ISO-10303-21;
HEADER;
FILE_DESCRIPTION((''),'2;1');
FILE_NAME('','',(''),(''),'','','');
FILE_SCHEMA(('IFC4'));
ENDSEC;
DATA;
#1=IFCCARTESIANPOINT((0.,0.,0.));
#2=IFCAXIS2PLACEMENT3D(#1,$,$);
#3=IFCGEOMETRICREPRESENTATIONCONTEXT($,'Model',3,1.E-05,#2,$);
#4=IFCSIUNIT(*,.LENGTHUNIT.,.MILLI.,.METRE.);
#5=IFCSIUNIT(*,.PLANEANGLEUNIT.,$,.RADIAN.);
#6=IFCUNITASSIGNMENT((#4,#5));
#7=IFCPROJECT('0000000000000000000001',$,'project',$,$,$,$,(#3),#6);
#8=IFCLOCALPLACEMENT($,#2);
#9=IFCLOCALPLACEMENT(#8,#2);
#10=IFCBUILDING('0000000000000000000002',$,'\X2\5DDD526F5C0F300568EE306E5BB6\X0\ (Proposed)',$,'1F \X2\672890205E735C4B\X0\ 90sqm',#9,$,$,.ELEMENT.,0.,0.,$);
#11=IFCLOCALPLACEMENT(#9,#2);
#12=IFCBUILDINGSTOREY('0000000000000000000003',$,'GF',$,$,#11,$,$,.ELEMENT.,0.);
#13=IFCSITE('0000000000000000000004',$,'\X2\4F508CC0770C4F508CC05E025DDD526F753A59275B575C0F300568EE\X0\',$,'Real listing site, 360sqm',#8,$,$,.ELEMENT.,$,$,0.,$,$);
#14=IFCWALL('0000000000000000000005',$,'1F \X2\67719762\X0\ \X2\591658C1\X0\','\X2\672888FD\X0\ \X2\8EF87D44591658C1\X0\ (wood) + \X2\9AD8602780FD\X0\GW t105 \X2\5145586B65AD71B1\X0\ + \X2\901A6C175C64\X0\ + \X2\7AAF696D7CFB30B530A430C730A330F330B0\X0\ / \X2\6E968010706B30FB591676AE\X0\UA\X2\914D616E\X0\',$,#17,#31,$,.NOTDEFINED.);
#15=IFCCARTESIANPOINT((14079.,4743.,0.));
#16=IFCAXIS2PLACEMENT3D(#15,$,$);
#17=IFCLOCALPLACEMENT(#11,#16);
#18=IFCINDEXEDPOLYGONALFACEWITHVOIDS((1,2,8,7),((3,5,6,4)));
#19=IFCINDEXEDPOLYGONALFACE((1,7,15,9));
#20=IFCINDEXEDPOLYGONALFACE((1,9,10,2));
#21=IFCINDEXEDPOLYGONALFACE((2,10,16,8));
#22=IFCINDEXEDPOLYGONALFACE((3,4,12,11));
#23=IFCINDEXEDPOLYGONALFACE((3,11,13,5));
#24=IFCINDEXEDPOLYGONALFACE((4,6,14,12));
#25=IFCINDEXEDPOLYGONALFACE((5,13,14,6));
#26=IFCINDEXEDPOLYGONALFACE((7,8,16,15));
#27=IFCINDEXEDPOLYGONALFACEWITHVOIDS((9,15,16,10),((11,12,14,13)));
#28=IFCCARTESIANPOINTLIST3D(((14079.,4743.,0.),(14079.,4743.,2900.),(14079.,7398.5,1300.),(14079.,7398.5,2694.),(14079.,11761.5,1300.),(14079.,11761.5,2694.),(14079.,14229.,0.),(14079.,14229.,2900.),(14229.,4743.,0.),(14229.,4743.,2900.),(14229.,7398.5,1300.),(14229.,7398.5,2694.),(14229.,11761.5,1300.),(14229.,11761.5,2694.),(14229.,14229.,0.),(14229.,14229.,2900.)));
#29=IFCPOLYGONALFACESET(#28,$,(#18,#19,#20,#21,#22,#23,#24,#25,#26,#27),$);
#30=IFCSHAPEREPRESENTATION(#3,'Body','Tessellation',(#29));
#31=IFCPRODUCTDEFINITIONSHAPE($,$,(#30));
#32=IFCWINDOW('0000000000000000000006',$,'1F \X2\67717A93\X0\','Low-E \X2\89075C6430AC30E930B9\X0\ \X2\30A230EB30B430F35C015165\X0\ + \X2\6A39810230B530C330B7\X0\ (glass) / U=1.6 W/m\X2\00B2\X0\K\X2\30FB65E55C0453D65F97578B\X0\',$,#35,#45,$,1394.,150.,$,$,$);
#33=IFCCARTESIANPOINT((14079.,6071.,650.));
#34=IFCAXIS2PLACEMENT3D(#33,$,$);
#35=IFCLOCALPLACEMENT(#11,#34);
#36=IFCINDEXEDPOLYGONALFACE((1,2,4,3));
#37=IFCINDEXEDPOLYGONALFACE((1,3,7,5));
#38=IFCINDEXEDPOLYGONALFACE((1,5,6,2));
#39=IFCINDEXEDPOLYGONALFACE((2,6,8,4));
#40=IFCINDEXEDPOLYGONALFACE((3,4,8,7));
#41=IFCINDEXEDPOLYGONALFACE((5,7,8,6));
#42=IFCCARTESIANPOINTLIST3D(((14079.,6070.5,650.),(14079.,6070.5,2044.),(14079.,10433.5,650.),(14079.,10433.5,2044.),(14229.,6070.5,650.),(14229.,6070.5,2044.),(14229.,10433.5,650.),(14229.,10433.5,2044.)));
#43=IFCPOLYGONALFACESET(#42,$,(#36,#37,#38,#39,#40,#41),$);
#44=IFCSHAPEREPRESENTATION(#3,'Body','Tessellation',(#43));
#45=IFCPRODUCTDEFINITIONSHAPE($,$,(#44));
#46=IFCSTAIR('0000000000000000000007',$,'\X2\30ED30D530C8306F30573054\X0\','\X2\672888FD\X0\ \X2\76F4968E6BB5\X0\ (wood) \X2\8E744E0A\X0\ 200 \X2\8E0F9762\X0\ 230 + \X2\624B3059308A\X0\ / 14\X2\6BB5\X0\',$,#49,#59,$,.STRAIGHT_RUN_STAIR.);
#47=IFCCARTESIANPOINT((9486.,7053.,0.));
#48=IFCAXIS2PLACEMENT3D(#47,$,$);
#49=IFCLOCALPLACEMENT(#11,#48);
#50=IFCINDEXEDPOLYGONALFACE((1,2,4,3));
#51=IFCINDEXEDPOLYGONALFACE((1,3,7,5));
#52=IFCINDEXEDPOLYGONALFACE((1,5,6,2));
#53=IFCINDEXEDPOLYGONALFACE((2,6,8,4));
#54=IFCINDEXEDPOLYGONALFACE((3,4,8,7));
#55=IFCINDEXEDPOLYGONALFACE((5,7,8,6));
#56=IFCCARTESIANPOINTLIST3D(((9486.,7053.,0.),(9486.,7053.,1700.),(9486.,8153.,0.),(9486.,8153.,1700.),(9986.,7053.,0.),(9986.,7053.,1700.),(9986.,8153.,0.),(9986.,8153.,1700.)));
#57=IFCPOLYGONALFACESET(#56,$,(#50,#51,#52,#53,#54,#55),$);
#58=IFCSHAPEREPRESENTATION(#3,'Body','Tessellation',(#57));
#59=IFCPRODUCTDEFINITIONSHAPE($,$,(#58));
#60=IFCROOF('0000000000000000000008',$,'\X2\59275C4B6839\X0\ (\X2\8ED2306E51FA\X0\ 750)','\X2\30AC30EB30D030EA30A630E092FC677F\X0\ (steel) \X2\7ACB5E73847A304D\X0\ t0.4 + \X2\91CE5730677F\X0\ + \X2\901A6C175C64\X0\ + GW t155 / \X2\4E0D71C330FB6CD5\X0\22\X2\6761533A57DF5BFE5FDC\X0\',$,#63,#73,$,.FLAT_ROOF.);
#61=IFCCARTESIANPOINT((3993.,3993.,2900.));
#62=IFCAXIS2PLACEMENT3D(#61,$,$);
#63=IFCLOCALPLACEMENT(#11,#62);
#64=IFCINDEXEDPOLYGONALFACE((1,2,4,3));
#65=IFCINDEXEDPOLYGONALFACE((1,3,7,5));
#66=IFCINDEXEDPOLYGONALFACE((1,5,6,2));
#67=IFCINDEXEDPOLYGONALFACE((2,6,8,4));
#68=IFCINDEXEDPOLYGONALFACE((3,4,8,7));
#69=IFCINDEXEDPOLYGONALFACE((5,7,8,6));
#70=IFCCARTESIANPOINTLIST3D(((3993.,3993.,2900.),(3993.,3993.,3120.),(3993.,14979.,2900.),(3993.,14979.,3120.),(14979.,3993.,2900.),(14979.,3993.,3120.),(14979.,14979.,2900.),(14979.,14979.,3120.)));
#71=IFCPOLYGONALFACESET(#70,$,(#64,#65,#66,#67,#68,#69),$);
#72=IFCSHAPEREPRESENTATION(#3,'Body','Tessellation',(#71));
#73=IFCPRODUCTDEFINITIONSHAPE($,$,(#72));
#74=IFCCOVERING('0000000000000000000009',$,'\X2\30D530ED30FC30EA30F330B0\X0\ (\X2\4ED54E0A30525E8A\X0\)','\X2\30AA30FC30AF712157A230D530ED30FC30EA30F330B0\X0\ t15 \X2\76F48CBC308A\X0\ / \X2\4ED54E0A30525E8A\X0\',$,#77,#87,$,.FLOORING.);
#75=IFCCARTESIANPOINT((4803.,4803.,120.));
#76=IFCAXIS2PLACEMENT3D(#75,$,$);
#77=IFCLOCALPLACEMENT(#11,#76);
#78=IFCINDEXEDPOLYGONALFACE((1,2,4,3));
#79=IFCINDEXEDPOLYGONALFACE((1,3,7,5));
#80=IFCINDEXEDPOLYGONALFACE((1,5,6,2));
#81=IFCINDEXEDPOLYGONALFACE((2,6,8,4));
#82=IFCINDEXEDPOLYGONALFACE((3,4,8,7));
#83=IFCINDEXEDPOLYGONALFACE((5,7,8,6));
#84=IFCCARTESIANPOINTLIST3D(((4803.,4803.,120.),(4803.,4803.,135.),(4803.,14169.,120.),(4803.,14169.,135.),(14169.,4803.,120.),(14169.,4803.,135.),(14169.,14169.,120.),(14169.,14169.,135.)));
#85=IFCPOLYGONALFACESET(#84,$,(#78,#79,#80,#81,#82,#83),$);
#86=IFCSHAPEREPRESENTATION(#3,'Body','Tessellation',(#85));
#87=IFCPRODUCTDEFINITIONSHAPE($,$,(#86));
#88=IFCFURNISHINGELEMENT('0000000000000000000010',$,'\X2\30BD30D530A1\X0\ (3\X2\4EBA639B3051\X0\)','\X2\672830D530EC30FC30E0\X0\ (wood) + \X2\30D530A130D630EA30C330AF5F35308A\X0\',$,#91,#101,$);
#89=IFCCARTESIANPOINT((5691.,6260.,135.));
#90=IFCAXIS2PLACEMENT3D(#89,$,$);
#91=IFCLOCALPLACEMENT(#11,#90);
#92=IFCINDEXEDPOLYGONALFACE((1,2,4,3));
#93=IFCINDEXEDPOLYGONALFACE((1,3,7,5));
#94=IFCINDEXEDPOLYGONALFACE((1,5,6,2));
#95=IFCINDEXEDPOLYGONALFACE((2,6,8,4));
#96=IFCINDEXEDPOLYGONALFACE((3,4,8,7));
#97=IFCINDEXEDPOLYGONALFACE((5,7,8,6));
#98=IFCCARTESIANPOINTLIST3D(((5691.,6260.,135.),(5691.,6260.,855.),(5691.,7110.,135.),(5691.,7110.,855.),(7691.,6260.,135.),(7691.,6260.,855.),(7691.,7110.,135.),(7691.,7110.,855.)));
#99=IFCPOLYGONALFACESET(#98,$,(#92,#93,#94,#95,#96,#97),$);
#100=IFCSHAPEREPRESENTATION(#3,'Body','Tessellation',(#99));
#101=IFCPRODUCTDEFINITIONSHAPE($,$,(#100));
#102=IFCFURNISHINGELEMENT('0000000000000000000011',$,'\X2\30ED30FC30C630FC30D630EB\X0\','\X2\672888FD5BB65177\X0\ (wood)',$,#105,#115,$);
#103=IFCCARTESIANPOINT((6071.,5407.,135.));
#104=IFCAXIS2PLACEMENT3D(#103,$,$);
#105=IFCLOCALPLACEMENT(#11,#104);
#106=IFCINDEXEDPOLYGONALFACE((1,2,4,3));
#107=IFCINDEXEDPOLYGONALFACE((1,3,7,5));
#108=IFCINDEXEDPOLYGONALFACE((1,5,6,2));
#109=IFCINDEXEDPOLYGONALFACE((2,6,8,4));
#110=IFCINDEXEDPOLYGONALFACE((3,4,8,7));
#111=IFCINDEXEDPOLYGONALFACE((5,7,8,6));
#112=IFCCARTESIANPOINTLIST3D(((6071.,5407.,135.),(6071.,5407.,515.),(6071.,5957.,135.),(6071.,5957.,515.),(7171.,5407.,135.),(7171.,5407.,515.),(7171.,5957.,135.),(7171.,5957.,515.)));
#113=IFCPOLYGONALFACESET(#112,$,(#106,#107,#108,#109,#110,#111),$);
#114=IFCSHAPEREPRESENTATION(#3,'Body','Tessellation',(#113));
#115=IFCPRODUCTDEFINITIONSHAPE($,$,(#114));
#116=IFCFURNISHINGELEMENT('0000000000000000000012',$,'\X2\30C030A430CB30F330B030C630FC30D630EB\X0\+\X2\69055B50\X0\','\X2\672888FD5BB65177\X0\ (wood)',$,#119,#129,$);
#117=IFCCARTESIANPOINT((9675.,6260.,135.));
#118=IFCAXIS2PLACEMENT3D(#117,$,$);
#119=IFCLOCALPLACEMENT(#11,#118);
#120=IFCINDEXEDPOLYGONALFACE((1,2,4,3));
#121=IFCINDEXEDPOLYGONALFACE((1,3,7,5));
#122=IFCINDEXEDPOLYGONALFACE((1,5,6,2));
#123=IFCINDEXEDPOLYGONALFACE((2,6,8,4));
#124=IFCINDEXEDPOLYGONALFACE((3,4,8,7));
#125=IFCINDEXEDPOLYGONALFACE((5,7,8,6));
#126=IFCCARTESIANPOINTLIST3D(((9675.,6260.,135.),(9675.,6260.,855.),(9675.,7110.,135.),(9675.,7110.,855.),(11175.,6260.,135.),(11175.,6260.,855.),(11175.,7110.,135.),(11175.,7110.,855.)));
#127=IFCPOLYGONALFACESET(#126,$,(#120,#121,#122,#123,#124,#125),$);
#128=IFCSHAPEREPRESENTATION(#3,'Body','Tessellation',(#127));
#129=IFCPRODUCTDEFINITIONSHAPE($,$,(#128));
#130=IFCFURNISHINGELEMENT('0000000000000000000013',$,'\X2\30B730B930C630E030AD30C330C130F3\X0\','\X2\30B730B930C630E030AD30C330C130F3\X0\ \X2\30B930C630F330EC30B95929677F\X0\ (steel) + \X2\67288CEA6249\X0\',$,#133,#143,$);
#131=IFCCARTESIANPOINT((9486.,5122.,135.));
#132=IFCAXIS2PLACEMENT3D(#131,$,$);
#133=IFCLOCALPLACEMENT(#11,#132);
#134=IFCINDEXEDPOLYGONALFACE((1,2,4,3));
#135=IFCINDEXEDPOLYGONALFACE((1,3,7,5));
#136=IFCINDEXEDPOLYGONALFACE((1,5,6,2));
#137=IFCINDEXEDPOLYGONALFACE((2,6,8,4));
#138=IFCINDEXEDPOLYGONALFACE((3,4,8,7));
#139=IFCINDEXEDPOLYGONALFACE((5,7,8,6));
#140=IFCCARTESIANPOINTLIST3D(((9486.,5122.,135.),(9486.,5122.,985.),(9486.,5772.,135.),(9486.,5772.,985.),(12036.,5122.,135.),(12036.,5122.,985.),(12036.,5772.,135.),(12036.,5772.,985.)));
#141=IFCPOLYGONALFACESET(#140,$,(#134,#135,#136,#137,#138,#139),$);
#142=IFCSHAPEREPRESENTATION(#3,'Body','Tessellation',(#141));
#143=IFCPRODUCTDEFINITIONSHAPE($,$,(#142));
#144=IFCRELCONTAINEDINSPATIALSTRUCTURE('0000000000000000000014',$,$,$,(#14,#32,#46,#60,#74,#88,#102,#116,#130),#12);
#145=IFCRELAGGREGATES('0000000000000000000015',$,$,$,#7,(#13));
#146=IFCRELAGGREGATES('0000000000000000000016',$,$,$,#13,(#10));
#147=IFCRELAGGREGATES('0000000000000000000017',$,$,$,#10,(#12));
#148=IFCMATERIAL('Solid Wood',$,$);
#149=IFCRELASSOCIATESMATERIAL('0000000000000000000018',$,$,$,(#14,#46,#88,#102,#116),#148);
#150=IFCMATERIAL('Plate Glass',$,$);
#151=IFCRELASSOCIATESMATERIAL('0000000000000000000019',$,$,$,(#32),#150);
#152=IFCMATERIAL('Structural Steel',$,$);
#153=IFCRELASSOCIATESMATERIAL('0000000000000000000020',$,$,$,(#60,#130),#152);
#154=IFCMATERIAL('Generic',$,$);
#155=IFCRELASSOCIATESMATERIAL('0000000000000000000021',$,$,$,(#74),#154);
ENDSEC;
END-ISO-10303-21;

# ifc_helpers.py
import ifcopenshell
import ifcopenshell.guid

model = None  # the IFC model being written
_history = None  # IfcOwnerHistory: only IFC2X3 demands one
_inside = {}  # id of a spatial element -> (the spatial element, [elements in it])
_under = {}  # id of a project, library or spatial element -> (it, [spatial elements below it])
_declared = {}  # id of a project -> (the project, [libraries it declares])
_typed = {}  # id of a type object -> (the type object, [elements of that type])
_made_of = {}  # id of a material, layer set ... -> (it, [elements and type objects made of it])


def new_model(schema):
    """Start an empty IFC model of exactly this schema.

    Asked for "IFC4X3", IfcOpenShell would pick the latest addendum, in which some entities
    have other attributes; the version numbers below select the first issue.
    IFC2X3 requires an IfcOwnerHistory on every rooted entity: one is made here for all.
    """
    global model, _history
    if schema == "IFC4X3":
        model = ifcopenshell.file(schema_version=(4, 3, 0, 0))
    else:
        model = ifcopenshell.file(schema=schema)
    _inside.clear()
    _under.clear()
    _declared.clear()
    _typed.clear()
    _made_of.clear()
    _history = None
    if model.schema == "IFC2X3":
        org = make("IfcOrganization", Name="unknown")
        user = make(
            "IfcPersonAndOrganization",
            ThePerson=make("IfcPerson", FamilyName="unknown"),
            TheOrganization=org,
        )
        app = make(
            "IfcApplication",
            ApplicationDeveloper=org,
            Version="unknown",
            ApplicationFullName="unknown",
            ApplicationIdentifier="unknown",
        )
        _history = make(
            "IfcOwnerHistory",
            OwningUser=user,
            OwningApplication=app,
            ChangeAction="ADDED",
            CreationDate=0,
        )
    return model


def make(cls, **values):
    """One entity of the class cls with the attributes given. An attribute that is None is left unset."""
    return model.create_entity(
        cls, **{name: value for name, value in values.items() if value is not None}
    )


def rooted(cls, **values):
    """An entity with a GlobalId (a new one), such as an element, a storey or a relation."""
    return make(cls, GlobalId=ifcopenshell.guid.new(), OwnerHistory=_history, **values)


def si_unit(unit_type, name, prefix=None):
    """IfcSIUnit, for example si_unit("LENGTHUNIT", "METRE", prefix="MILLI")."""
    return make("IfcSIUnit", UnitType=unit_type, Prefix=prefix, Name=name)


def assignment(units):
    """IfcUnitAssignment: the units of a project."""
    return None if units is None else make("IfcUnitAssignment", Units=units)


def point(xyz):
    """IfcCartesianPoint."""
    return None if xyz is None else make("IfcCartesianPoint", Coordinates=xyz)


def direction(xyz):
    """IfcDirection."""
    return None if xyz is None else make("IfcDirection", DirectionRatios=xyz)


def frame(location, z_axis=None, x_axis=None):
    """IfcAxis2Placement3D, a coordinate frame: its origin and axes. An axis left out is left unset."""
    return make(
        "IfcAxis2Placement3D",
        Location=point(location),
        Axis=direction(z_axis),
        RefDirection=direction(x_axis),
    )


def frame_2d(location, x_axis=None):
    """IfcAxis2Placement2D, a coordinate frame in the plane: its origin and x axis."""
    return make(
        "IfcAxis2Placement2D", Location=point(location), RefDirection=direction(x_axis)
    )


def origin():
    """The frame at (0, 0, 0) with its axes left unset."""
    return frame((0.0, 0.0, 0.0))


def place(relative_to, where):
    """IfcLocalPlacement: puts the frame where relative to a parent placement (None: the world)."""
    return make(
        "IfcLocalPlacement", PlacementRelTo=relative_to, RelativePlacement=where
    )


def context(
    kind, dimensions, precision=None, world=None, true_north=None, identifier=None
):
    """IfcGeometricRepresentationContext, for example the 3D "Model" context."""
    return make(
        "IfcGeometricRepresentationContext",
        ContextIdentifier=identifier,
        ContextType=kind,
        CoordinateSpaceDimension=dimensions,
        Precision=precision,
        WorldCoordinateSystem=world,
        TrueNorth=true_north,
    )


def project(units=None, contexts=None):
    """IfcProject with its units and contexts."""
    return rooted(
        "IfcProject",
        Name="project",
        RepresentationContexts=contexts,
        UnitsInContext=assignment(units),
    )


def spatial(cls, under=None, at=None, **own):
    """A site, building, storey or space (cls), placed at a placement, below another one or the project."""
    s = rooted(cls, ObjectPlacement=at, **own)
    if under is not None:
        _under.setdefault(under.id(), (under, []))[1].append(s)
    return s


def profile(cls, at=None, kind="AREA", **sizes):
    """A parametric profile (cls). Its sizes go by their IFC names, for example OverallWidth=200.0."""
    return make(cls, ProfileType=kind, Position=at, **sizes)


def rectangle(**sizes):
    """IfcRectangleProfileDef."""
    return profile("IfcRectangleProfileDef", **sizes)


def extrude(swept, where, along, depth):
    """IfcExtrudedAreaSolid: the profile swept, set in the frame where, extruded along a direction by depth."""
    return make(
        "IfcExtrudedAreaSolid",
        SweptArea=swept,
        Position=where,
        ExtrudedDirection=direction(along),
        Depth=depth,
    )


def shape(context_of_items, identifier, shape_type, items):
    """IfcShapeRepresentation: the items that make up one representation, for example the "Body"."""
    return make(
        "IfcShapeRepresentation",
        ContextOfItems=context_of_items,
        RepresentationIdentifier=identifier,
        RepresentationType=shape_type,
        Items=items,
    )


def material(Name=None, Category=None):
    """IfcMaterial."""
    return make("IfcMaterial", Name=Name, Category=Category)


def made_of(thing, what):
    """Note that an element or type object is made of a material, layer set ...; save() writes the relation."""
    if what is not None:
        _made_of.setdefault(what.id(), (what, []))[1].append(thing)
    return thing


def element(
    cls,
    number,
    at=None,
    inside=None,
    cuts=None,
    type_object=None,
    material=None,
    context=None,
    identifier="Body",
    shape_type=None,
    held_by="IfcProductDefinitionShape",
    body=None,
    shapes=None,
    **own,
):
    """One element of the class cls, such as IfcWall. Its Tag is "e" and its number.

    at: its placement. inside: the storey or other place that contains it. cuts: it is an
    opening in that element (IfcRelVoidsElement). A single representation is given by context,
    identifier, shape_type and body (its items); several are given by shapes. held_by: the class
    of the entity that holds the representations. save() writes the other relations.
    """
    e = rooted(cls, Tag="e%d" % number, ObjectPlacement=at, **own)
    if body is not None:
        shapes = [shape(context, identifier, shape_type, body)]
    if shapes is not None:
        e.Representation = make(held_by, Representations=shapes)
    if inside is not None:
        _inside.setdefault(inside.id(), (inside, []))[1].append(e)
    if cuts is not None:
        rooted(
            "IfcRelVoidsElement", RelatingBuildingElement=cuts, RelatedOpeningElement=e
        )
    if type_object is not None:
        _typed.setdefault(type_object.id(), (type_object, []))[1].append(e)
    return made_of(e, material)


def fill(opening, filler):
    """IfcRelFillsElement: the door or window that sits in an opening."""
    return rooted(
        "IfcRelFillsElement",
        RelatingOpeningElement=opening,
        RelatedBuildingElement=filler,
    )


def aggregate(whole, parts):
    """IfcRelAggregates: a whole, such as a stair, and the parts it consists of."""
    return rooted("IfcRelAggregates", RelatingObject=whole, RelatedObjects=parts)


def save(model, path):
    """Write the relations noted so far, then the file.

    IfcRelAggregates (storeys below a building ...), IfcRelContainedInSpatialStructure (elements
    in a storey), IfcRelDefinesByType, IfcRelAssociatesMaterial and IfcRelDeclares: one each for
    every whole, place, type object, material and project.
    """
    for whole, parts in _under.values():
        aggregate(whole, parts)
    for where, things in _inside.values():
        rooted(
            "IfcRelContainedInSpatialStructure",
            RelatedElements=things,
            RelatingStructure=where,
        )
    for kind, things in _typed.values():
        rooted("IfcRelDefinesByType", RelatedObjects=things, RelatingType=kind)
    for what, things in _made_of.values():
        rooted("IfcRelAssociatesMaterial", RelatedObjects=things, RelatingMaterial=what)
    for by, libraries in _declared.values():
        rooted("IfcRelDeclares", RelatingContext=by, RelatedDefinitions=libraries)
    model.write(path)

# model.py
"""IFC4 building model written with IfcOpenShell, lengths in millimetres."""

from ifc_helpers import new_model, si_unit, frame, frame_2d, origin, place, context, project, spatial, rectangle, extrude, material, element, fill, save


model = new_model("IFC4")

# Units and contexts
model_context = context("Model", 3, precision=1e-05, world=origin())
ifc_project = project(units=[si_unit("LENGTHUNIT", "METRE", prefix="MILLI"), si_unit("PLANEANGLEUNIT", "RADIAN")], contexts=[model_context])

# Site, building, storey
site_placement = place(None, origin())
site = spatial("IfcSite", under=ifc_project, at=site_placement, Name="佐賀県佐賀市川副町大字小々森", ObjectType="Real listing site, 360sqm", CompositionType="ELEMENT", RefElevation=0.0)
building_placement = place(site_placement, origin())
building = spatial("IfcBuilding", under=site, at=building_placement, Name="川副小々森の家 (Proposed)", ObjectType="1F 木造平屋 90sqm", CompositionType="ELEMENT", ElevationOfRefHeight=0.0, ElevationOfTerrain=0.0)
storey_placement = place(building_placement, origin())
storey = spatial("IfcBuildingStorey", under=building, at=storey_placement, Name="GF", CompositionType="ELEMENT", Elevation=0.0)

# Shared definitions
ifc_material_1 = material(Name="Solid Wood")

# Shared definitions
ifc_material_2 = material(Name="Plate Glass")

# Wall, opening, window
wall_1_placement = place(storey_placement, frame((14079.0, 4743.0, 0.0)))
wall_1 = element("IfcWall", 1, at=wall_1_placement, inside=storey, material=ifc_material_1, Name="1F 東面 外壁", Description="木製 軸組外壁 (wood) + 高性能GW t105 充填断熱 + 通気層 + 窯業系サイディング / 準耐火・外皮UA配慮", PredefinedType="NOTDEFINED", context=model_context, shape_type="SweptSolid", body=[
    extrude(rectangle(XDim=150.0, YDim=9486.0, at=frame_2d((75.0, 4743.0))), frame((14079.0, 4743.0, 0.0)), (0.0, 0.0, 1.0), 2900.0),
])
opening_1_placement = place(storey_placement, frame((14079.0, 6071.0, 650.0)))
opening_1 = element("IfcOpeningElement", 2, at=opening_1_placement, cuts=wall_1, PredefinedType="NOTDEFINED", context=model_context, shape_type="SweptSolid", body=[
    extrude(rectangle(XDim=150.0, YDim=4363.0, at=frame_2d((75.0, 2181.0))), frame((14079.0, 6071.0, 650.0)), (0.0, 0.0, 1.0), 1394.0),
])
window_1_placement = place(storey_placement, frame((14079.0, 6071.0, 650.0)))
window_1 = element("IfcWindow", 3, at=window_1_placement, inside=storey, material=ifc_material_2, Name="1F 東窓", Description="Low-E 複層ガラス アルゴン封入 + 樹脂サッシ (glass) / U=1.6 W/m²K・日射取得型", OverallHeight=1394.0, OverallWidth=150.0, context=model_context, shape_type="SweptSolid", body=[
    extrude(rectangle(XDim=150.0, YDim=4363.0, at=frame_2d((75.0, 2181.0))), frame((14079.0, 6071.0, 650.0)), (0.0, 0.0, 1.0), 1394.0),
])
fill(opening_1, window_1)

# Stair
stair_placement = place(storey_placement, frame((9486.0, 7053.0, 0.0)))
element("IfcStair", 4, at=stair_placement, inside=storey, material=ifc_material_1, Name="ロフトはしご", Description="木製 直階段 (wood) 蹴上 200 踏面 230 + 手すり / 14段", PredefinedType="STRAIGHT_RUN_STAIR", context=model_context, shape_type="SweptSolid", body=[
    extrude(rectangle(XDim=500.0, YDim=1100.0, at=frame_2d((250.0, 550.0))), frame((9486.0, 7053.0, 0.0)), (0.0, 0.0, 1.0), 1700.0),
])

# Roof
ifc_material_3 = material(Name="Structural Steel")
roof_placement = place(storey_placement, frame((3993.0, 3993.0, 2900.0)))
element("IfcRoof", 5, at=roof_placement, inside=storey, material=ifc_material_3, Name="大屋根 (軒の出 750)", Description="ガルバリウム鋼板 (steel) 立平葺き t0.4 + 野地板 + 通気層 + GW t155 / 不燃・法22条区域対応", PredefinedType="FLAT_ROOF", context=model_context, shape_type="SweptSolid", body=[
    extrude(rectangle(XDim=10986.0, YDim=10986.0, at=frame_2d((5493.0, 5493.0))), frame((3993.0, 3993.0, 2900.0)), (0.0, 0.0, 1.0), 220.0),
])

# Covering
ifc_material_4 = material(Name="Generic")
covering_placement = place(storey_placement, frame((4803.0, 4803.0, 120.0)))
element("IfcCovering", 6, at=covering_placement, inside=storey, material=ifc_material_4, Name="フローリング (仕上げ床)", Description="オーク無垢フローリング t15 直貼り / 仕上げ床", PredefinedType="FLOORING", context=model_context, shape_type="SweptSolid", body=[
    extrude(rectangle(XDim=9366.0, YDim=9366.0, at=frame_2d((4683.0, 4683.0))), frame((4803.0, 4803.0, 120.0)), (0.0, 0.0, 1.0), 15.0),
])

# Furnishing elements
furnishing_1_placement = place(storey_placement, frame((5691.0, 6260.0, 135.0)))
element("IfcFurnishingElement", 7, at=furnishing_1_placement, inside=storey, material=ifc_material_1, Name="ソファ (3人掛け)", Description="木フレーム (wood) + ファブリック張り", context=model_context, shape_type="SweptSolid", body=[
    extrude(rectangle(XDim=2000.0, YDim=850.0, at=frame_2d((1000.0, 425.0))), frame((5691.0, 6260.0, 135.0)), (0.0, 0.0, 1.0), 720.0),
])
furnishing_2_placement = place(storey_placement, frame((6071.0, 5407.0, 135.0)))
element("IfcFurnishingElement", 8, at=furnishing_2_placement, inside=storey, material=ifc_material_1, Name="ローテーブル", Description="木製家具 (wood)", context=model_context, shape_type="SweptSolid", body=[
    extrude(rectangle(XDim=1100.0, YDim=550.0, at=frame_2d((550.0, 275.0))), frame((6071.0, 5407.0, 135.0)), (0.0, 0.0, 1.0), 380.0),
])
furnishing_3_placement = place(storey_placement, frame((9675.0, 6260.0, 135.0)))
element("IfcFurnishingElement", 9, at=furnishing_3_placement, inside=storey, material=ifc_material_1, Name="ダイニングテーブル+椅子", Description="木製家具 (wood)", context=model_context, shape_type="SweptSolid", body=[
    extrude(rectangle(XDim=1500.0, YDim=850.0, at=frame_2d((750.0, 425.0))), frame((9675.0, 6260.0, 135.0)), (0.0, 0.0, 1.0), 720.0),
])
furnishing_4_placement = place(storey_placement, frame((9486.0, 5122.0, 135.0)))
element("IfcFurnishingElement", 10, at=furnishing_4_placement, inside=storey, material=ifc_material_3, Name="システムキッチン", Description="システムキッチン ステンレス天板 (steel) + 木質扉", context=model_context, shape_type="SweptSolid", body=[
    extrude(rectangle(XDim=2550.0, YDim=650.0, at=frame_2d((1275.0, 325.0))), frame((9486.0, 5122.0, 135.0)), (0.0, 0.0, 1.0), 850.0),
])

save(model, "model.ifc")
